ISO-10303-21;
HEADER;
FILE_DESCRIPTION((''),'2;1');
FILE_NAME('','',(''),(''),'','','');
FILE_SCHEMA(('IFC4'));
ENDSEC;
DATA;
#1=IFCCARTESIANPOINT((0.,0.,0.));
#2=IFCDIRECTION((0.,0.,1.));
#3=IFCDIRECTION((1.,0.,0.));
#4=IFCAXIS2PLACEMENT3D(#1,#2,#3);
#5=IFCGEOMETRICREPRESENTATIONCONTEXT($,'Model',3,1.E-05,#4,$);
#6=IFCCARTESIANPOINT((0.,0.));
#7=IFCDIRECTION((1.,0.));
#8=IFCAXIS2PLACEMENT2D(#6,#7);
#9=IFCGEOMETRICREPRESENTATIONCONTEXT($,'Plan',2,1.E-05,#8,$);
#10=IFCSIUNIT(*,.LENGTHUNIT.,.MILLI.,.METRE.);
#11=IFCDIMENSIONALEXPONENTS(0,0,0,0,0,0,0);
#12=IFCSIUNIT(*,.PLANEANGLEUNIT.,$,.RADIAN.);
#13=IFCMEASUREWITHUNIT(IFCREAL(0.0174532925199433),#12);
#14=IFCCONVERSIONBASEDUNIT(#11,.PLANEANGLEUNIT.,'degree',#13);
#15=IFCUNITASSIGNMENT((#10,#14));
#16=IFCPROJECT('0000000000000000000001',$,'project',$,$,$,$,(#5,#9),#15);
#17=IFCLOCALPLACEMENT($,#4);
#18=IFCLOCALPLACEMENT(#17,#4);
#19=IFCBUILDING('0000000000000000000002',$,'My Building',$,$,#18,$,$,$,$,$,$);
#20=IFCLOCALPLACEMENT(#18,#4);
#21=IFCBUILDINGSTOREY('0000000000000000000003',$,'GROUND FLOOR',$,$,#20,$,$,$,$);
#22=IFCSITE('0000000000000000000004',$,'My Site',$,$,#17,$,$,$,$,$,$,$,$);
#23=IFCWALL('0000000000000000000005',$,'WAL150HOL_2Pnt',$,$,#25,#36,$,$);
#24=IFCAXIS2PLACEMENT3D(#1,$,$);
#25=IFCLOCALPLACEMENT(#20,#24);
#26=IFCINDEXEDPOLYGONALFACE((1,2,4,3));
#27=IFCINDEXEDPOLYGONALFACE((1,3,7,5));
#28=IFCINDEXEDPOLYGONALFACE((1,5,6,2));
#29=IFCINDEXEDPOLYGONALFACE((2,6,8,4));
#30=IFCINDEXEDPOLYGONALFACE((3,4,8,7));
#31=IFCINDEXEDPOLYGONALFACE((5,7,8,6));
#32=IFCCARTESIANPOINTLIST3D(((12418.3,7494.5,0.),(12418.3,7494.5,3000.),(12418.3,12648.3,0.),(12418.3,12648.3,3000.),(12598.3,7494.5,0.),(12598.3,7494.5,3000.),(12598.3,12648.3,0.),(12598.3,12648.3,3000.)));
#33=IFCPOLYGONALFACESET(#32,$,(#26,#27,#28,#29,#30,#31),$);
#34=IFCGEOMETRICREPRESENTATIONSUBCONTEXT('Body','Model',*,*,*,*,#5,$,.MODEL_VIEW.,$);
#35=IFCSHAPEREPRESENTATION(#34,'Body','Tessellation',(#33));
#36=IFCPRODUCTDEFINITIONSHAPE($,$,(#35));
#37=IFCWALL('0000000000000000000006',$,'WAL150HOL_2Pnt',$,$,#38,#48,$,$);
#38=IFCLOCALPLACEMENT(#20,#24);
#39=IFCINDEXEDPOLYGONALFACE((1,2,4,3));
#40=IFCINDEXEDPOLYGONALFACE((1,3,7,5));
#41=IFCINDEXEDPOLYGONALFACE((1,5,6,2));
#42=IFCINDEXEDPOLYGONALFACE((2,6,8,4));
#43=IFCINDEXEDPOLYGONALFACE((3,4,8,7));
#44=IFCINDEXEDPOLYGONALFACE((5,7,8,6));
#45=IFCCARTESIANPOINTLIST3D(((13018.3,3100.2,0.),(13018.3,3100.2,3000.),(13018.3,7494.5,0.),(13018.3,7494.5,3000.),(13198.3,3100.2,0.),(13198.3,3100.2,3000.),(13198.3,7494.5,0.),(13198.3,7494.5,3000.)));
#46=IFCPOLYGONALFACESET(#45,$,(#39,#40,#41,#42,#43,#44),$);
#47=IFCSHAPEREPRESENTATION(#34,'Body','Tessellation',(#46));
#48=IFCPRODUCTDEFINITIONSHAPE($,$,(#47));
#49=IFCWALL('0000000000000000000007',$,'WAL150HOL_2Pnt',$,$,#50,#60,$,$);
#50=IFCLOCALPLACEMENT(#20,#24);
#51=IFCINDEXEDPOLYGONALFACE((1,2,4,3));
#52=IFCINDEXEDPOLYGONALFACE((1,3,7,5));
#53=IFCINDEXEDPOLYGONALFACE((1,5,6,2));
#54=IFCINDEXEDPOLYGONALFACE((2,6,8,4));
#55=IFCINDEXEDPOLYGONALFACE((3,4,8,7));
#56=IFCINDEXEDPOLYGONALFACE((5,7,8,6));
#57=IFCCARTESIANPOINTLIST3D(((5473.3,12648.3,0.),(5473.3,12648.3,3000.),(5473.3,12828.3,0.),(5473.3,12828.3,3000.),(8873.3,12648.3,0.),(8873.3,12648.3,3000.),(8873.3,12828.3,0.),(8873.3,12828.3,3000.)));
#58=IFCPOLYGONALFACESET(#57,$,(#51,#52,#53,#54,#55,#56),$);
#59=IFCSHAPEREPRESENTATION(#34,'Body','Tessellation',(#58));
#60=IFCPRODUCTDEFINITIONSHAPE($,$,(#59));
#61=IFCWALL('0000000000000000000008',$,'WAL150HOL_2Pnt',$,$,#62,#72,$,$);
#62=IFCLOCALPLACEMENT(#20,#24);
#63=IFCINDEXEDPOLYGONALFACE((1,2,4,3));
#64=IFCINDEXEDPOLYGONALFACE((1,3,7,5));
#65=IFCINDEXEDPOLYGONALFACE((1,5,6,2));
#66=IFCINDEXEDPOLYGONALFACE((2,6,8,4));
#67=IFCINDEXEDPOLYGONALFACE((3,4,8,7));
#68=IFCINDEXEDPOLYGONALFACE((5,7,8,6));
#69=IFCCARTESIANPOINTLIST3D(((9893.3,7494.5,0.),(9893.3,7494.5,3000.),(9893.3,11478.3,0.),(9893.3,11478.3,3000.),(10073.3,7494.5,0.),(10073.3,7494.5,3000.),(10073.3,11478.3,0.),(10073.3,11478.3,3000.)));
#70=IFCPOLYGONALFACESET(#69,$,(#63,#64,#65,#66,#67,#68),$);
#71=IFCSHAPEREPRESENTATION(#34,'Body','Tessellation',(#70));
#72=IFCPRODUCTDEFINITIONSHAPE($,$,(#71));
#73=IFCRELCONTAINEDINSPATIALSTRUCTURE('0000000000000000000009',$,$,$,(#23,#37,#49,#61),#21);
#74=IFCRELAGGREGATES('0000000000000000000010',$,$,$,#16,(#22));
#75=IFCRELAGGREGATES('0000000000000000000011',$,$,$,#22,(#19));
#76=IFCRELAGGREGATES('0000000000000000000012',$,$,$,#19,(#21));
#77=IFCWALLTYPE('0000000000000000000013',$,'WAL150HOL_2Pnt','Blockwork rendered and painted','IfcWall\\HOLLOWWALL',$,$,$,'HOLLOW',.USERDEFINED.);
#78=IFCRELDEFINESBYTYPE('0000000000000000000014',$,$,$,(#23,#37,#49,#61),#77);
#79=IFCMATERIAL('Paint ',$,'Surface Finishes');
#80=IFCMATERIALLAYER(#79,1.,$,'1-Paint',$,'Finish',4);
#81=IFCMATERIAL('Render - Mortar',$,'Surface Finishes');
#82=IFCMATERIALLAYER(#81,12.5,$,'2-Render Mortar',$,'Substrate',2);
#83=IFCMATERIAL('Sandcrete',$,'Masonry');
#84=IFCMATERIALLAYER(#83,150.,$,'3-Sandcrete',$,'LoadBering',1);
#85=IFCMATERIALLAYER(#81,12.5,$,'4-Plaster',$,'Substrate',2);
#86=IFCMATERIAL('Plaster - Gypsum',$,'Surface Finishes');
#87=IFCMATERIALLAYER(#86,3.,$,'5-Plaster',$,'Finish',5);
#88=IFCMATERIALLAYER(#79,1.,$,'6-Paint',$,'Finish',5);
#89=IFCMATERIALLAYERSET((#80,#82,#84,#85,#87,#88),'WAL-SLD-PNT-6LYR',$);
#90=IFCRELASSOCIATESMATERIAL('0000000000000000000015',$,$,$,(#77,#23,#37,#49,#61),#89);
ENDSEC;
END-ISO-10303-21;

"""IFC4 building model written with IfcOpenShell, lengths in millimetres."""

from ifc_helpers import new_model, entity, si_unit, converted_unit, frame, origin_with_axes, origin_2d_with_axis, place, context, subcontext, project, spatial, indexed_curve, outline, extrude, material, layer, layer_set, layer_usage, type_object, element, save


model = new_model("IFC4")

# Units and contexts
model_context = context("Model", 3, precision=1e-05, world=origin_with_axes())
plan_context = context("Plan", 2, precision=1e-05, world=origin_2d_with_axis())
body_context_1 = subcontext(model_context, "Body", "Model", "MODEL_VIEW")
ifc_project = project(units=[si_unit("LENGTHUNIT", "METRE", prefix="MILLI"), converted_unit("PLANEANGLEUNIT", "degree", entity("IfcReal", 0.0174532925199433), si_unit("PLANEANGLEUNIT", "RADIAN"), dimensions=[0, 0, 0, 0, 0, 0, 0])], contexts=[model_context, plan_context])

# Site, building, storey
site_placement = place(None, origin_with_axes())
site = spatial("IfcSite", under=ifc_project, at=site_placement, Name="My Site")
building_placement = place(site_placement, origin_with_axes())
building = spatial("IfcBuilding", under=site, at=building_placement, Name="My Building")
storey_placement = place(building_placement, origin_with_axes())
storey = spatial("IfcBuildingStorey", under=building, at=storey_placement, Name="GROUND FLOOR")

# Shared definitions
ifc_material_1 = material(Name="Paint ", Category="Surface Finishes")
ifc_layer_1 = layer(ifc_material_1, 1.0, Name="1-Paint", Category="Finish", Priority=4)
ifc_material_2 = material(Name="Render - Mortar", Category="Surface Finishes")
ifc_layer_2 = layer(ifc_material_2, 12.5, Name="2-Render Mortar", Category="Substrate", Priority=2)
ifc_material_3 = material(Name="Sandcrete", Category="Masonry")
ifc_layer_3 = layer(ifc_material_3, 150.0, Name="3-Sandcrete", Category="LoadBering", Priority=1)
ifc_layer_4 = layer(ifc_material_2, 12.5, Name="4-Plaster", Category="Substrate", Priority=2)
ifc_material_4 = material(Name="Plaster - Gypsum", Category="Surface Finishes")
ifc_layer_5 = layer(ifc_material_4, 3.0, Name="5-Plaster", Category="Finish", Priority=5)
ifc_layer_6 = layer(ifc_material_1, 1.0, Name="6-Paint", Category="Finish", Priority=5)
ifc_layer_set_1 = layer_set([ifc_layer_1, ifc_layer_2, ifc_layer_3, ifc_layer_4, ifc_layer_5, ifc_layer_6], Name="WAL-SLD-PNT-6LYR")
wall_type_1 = type_object("IfcWallType", Name="WAL150HOL_2Pnt", Description="Blockwork rendered and painted", ApplicableOccurrence="IfcWall\\HOLLOWWALL", ElementType="HOLLOW", PredefinedType="USERDEFINED", material=ifc_layer_set_1)

# Walls
ifc_layer_usage_1 = layer_usage(ifc_layer_set_1, "AXIS2", "POSITIVE", 0.0)
wall_1_placement = place(storey_placement, frame((12598.3, 7494.5, 0.0), z_axis=(0.0, 0.0, 1.0), x_axis=(0.000001, 1.0, 0.0)))
element("IfcWall", 1, at=wall_1_placement, inside=storey, type_object=wall_type_1, material=ifc_layer_usage_1, Name="WAL150HOL_2Pnt", context=body_context_1, shape_type="SweptSolid", body=[
    extrude(outline(indexed_curve([(0.0, 0.0), (0.0, 180.0), (5153.8, 180.0), (5153.8, 0.0), (0.0, 0.0)], self_intersect=False)), origin_with_axes(), (0.0, 0.0, 1.0), 3000.0),
])
ifc_layer_usage_2 = layer_usage(ifc_layer_set_1, "AXIS2", "POSITIVE", 0.0)
wall_2_placement = place(storey_placement, frame((13198.3, 3100.2, 0.0), z_axis=(0.0, 0.0, 1.0), x_axis=(0.000001, 1.0, 0.0)))
element("IfcWall", 2, at=wall_2_placement, inside=storey, type_object=wall_type_1, material=ifc_layer_usage_2, Name="WAL150HOL_2Pnt", context=body_context_1, shape_type="SweptSolid", body=[
    extrude(outline(indexed_curve([(0.0, 0.0), (0.0, 180.0), (4394.3, 180.0), (4394.3, 0.0), (0.0, 0.0)], self_intersect=False)), origin_with_axes(), (0.0, 0.0, 1.0), 3000.0),
])
ifc_layer_usage_3 = layer_usage(ifc_layer_set_1, "AXIS2", "POSITIVE", 0.0)
wall_3_placement = place(storey_placement, frame((8873.3, 12828.3, 0.0), z_axis=(0.0, 0.0, 1.0), x_axis=(-1.0, 0.000001, 0.0)))
element("IfcWall", 3, at=wall_3_placement, inside=storey, type_object=wall_type_1, material=ifc_layer_usage_3, Name="WAL150HOL_2Pnt", context=body_context_1, shape_type="SweptSolid", body=[
    extrude(outline(indexed_curve([(0.0, 0.0), (0.0, 180.0), (3400.0, 180.0), (3400.0, 0.0), (0.0, 0.0)], self_intersect=False)), origin_with_axes(), (0.0, 0.0, 1.0), 3000.0),
])
ifc_layer_usage_4 = layer_usage(ifc_layer_set_1, "AXIS2", "POSITIVE", 0.0)
wall_4_placement = place(storey_placement, frame((9893.3, 11478.3, 0.0), z_axis=(0.0, 0.0, 1.0), x_axis=(-0.000001, -1.0, 0.0)))
element("IfcWall", 4, at=wall_4_placement, inside=storey, type_object=wall_type_1, material=ifc_layer_usage_4, Name="WAL150HOL_2Pnt", context=body_context_1, shape_type="SweptSolid", body=[
    extrude(outline(indexed_curve([(0.0, 0.0), (0.0, 180.0), (3983.8, 180.0), (3983.8, 0.0), (0.0, 0.0)], self_intersect=False)), origin_with_axes(), (0.0, 0.0, 1.0), 3000.0),
])

save(model, "model.ifc")
